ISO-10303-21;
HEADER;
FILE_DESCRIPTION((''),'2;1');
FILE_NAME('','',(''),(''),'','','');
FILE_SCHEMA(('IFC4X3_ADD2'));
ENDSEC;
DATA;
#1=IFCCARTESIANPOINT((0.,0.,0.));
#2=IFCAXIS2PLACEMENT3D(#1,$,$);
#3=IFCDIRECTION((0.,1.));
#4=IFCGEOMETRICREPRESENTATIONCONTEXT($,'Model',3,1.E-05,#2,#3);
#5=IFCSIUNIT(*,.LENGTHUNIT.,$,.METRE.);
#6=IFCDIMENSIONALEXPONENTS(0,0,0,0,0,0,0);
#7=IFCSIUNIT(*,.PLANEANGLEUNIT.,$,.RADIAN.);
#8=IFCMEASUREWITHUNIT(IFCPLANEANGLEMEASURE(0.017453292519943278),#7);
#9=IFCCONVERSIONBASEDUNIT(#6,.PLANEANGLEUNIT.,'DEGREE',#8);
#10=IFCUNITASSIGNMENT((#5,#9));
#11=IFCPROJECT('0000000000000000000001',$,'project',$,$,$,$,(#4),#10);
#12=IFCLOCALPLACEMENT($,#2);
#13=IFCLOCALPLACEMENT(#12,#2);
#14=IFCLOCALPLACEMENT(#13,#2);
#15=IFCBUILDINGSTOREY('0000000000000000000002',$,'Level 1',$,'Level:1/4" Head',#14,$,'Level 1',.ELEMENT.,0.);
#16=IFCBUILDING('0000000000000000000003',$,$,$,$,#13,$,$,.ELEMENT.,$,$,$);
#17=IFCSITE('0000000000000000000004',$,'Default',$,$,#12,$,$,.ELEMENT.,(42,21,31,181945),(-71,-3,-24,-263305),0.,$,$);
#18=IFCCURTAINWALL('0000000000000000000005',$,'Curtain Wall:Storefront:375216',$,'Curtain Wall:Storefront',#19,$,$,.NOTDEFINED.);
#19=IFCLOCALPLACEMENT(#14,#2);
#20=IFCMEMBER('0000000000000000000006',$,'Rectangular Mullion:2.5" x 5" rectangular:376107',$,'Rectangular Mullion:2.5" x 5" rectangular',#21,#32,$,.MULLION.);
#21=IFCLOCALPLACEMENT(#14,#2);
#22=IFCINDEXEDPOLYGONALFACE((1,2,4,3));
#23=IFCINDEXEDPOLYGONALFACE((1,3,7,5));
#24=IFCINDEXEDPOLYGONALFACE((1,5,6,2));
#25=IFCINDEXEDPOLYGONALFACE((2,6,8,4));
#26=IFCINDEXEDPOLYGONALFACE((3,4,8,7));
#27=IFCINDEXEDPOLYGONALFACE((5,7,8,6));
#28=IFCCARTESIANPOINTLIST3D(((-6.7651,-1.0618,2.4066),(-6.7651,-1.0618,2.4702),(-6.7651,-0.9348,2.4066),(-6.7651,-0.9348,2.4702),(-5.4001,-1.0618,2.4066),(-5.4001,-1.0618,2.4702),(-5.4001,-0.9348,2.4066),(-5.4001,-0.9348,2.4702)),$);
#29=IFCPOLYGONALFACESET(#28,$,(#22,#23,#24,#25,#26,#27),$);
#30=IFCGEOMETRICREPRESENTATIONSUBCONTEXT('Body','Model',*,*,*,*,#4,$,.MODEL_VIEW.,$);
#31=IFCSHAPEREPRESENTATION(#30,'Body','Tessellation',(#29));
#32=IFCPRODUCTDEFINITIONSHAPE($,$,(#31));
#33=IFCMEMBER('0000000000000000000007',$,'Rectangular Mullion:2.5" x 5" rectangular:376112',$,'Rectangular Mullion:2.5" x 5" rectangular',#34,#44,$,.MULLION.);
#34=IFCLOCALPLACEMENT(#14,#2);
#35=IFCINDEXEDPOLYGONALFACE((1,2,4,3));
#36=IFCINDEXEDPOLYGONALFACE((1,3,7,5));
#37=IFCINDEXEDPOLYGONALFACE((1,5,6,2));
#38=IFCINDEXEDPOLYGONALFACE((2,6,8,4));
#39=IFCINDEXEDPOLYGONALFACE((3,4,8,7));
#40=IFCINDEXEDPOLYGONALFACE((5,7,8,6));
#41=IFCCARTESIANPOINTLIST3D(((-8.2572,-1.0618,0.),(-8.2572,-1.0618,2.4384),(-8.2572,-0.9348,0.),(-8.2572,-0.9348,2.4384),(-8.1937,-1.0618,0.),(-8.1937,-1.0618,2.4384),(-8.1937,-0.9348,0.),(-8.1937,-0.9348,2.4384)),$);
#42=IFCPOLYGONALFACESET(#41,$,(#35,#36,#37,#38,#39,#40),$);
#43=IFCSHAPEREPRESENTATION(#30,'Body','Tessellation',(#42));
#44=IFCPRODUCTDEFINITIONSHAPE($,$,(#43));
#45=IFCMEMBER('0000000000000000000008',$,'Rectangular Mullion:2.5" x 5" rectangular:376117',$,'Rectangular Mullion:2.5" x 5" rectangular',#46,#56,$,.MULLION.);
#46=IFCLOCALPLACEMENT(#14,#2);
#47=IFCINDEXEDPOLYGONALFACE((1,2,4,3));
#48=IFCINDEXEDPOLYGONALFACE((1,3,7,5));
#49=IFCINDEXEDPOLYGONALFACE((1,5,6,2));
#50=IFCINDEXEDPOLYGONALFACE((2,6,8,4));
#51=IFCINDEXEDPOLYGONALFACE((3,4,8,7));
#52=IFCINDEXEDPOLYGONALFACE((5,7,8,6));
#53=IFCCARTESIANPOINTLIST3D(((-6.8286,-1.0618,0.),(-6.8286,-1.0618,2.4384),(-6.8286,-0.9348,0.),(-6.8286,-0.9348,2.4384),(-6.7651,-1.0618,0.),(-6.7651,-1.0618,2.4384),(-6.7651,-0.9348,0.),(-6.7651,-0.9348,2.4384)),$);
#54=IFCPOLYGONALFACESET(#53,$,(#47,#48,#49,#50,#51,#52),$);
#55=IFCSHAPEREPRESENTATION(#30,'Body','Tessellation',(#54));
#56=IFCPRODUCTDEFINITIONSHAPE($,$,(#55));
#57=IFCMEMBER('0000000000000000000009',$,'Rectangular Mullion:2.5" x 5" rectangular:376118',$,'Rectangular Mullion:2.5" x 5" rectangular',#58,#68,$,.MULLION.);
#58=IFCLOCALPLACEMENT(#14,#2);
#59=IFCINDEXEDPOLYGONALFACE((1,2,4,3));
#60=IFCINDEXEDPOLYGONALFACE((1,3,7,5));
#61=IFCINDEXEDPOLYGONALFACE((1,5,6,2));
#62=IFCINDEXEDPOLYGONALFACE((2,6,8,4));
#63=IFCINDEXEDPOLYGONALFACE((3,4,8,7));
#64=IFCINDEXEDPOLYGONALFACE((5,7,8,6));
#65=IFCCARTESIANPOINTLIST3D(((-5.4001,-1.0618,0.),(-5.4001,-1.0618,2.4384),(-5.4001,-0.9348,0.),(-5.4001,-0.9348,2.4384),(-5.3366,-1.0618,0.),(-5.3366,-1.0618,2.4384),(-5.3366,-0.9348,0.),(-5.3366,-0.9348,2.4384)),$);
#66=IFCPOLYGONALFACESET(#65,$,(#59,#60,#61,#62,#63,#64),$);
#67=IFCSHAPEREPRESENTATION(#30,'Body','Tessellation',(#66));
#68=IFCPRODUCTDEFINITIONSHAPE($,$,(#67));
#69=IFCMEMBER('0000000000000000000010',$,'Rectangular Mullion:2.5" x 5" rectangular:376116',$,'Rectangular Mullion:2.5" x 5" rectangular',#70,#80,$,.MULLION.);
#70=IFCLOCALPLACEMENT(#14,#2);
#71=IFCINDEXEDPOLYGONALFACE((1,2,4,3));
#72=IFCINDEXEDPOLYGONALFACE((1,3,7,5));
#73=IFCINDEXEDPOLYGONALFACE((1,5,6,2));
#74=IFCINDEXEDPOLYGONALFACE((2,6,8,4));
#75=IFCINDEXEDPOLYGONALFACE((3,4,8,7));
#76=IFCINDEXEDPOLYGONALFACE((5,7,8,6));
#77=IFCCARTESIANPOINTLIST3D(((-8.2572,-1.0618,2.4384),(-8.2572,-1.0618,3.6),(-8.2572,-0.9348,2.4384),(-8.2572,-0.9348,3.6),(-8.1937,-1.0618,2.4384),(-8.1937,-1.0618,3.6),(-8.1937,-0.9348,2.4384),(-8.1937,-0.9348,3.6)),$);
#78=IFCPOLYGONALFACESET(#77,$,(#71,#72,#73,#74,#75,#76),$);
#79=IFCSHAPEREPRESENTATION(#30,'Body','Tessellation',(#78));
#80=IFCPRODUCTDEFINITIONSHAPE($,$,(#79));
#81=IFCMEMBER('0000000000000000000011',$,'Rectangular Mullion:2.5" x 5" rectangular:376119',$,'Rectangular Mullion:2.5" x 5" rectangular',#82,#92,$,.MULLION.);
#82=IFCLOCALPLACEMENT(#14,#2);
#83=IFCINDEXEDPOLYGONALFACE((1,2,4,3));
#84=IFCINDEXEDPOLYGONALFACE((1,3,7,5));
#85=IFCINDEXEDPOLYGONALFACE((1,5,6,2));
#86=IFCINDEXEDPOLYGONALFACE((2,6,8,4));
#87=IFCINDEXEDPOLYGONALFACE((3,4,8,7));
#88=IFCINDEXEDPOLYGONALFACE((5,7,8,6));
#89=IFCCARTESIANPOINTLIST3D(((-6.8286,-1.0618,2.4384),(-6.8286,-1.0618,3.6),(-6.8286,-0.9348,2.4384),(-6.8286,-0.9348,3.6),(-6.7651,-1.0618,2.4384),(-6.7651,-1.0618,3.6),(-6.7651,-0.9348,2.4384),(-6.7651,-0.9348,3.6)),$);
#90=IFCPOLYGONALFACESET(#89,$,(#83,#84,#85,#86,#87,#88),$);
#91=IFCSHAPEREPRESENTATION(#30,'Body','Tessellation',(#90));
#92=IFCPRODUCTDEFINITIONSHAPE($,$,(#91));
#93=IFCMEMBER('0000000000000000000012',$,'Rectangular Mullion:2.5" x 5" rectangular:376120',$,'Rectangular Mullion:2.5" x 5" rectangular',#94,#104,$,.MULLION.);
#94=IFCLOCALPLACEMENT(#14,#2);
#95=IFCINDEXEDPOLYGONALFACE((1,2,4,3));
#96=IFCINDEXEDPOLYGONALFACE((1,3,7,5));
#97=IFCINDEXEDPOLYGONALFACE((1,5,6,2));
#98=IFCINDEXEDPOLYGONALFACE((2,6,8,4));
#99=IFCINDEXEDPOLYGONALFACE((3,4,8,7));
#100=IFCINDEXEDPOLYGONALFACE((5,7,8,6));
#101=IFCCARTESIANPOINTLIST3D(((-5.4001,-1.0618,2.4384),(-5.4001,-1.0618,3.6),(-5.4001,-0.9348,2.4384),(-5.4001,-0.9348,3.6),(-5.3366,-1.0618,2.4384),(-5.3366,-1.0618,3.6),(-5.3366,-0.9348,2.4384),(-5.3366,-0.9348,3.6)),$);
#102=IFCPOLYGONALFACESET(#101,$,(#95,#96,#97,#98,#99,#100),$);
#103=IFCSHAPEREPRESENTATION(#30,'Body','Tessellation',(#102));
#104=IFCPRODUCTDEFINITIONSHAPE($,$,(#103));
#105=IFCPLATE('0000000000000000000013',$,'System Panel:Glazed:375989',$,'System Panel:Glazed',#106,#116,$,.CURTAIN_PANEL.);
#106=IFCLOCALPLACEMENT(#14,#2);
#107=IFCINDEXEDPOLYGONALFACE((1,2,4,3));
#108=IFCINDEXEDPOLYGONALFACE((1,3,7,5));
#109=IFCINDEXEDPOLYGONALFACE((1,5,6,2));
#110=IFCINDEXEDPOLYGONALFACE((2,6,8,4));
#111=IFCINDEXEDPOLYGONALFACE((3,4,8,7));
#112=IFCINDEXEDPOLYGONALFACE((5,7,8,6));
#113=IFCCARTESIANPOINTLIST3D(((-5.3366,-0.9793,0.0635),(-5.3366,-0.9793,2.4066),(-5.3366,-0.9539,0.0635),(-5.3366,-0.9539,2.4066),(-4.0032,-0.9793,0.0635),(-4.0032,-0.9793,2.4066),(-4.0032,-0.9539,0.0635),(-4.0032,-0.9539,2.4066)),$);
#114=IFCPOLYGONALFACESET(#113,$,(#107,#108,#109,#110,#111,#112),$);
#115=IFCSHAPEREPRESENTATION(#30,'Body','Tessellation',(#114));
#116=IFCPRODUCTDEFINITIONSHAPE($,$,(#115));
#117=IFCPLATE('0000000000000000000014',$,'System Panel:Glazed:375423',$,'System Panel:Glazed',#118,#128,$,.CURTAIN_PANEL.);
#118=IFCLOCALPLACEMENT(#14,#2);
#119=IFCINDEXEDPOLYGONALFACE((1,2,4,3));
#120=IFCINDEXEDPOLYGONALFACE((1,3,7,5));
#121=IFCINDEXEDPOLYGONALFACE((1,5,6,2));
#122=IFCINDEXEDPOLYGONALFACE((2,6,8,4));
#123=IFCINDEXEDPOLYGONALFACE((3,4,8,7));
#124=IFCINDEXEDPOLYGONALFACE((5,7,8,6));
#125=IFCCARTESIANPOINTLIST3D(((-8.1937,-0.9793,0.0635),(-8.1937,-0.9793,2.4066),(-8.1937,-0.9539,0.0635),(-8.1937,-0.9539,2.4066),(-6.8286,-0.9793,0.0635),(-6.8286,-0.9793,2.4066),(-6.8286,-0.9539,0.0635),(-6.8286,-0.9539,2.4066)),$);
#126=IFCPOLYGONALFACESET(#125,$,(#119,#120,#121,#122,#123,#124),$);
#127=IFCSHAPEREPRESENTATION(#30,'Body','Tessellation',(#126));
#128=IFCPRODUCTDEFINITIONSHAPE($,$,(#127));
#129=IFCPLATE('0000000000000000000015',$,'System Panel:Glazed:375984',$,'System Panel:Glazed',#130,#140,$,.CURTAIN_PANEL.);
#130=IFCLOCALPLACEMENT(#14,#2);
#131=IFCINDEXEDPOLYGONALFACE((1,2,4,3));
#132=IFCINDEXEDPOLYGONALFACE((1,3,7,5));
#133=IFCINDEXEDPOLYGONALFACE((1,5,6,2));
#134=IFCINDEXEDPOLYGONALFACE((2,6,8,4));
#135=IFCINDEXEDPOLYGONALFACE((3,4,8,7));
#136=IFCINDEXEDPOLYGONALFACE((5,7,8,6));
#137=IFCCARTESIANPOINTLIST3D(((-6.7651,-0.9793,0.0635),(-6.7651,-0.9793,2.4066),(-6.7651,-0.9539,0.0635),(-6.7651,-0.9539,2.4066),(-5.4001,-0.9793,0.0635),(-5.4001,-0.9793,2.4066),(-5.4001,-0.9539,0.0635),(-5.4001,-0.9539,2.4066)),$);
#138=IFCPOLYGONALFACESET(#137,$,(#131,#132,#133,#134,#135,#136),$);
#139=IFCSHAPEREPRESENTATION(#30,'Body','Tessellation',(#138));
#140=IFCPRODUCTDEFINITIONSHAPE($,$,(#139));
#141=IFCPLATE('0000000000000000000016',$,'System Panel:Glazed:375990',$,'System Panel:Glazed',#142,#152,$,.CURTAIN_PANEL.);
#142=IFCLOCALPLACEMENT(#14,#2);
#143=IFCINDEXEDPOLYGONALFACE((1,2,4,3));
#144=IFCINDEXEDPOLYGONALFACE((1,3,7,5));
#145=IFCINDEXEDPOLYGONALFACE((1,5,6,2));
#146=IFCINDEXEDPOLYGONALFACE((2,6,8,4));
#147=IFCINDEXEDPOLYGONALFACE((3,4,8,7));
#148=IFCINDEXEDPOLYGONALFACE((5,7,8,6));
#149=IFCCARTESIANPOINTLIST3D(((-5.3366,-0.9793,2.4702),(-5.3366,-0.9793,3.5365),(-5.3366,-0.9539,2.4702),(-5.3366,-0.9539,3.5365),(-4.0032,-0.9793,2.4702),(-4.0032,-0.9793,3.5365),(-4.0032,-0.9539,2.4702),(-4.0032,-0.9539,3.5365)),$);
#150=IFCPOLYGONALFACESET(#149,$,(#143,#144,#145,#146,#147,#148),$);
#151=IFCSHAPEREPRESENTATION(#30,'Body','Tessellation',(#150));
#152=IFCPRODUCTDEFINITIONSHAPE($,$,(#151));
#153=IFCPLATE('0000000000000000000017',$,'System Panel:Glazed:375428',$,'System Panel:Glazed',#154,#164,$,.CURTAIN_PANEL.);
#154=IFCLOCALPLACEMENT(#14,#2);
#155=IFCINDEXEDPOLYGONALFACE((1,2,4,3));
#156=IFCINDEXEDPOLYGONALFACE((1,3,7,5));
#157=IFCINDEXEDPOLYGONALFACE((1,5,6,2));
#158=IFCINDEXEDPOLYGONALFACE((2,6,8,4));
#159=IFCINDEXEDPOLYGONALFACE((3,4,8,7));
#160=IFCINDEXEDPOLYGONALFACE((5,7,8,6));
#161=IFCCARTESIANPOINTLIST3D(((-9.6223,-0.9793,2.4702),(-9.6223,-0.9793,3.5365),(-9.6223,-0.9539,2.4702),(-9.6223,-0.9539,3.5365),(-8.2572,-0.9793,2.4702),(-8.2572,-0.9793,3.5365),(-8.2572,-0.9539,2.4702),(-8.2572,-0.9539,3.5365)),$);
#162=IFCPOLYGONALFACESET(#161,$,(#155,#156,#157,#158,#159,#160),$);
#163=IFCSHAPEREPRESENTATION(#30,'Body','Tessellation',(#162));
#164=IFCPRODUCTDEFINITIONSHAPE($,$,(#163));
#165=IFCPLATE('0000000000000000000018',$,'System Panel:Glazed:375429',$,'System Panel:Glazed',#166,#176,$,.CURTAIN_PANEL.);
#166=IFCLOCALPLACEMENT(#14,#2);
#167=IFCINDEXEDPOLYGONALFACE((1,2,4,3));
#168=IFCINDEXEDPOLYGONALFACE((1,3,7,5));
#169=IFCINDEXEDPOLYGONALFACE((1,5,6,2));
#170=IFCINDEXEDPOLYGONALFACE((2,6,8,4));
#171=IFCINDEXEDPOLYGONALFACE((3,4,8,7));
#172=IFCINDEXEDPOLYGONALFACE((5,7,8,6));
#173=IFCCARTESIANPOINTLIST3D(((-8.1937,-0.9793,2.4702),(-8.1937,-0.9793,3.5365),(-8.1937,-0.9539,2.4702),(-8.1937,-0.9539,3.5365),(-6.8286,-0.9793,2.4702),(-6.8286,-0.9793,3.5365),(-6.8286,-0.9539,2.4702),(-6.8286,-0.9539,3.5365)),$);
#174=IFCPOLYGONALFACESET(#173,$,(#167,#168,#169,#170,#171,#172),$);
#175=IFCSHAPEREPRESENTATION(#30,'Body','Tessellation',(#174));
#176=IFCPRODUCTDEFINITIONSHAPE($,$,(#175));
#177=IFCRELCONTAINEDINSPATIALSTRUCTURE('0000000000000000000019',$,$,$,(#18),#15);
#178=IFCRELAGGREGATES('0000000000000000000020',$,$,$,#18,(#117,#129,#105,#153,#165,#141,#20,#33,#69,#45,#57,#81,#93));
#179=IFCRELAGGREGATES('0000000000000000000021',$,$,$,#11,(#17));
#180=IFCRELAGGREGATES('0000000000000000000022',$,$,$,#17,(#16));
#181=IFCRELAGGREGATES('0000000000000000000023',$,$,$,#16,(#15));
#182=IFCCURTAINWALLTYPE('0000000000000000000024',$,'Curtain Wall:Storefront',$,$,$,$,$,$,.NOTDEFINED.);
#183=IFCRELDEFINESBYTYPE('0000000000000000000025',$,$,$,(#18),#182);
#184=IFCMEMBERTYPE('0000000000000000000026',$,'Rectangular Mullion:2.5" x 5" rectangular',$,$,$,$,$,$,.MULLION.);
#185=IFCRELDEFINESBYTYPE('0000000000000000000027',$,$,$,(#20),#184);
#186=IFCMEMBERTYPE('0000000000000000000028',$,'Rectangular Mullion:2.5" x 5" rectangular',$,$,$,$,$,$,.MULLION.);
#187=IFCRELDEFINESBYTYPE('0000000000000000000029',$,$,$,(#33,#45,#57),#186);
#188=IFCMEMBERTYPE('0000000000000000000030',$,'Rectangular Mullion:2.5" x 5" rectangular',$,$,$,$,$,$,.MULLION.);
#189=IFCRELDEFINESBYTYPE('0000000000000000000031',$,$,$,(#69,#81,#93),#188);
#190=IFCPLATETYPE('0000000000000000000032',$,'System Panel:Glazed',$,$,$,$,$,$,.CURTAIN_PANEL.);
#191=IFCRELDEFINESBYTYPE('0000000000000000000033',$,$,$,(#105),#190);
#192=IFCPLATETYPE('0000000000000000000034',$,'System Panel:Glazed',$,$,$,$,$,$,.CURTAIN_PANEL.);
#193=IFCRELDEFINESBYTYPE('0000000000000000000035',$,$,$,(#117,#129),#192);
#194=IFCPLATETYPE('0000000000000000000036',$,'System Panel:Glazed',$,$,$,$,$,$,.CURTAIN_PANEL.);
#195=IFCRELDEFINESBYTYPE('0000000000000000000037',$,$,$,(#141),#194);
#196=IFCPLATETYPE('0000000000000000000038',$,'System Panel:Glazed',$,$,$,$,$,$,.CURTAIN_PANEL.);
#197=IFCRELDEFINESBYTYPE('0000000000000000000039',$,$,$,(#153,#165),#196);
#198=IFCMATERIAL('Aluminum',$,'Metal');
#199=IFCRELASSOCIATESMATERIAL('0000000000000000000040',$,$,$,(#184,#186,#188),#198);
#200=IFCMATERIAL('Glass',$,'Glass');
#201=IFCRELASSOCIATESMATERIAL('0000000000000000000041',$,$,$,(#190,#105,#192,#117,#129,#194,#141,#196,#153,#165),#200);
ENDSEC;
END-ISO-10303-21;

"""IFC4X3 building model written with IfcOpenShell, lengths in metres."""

from ifc_helpers import new_model, entity, si_unit, converted_unit, direction, frame, frame_2d, origin, origin_2d_with_axis, place, context, subcontext, project, spatial, rectangle, extrude, source, transform, mapped, material, material_profile, profile_set, type_object, type_shapes, element, aggregate, save


model = new_model("IFC4X3")

# Units and contexts
model_context = context("Model", 3, precision=1e-05, world=origin(), true_north=direction((0.0, 1.0)))
body_context = subcontext(model_context, "Body", "Model", "MODEL_VIEW")
ifc_project = project(units=[si_unit("LENGTHUNIT", "METRE"), converted_unit("PLANEANGLEUNIT", "DEGREE", entity("IfcPlaneAngleMeasure", 0.017453292519943278), si_unit("PLANEANGLEUNIT", "RADIAN"), dimensions=[0, 0, 0, 0, 0, 0, 0])], contexts=[model_context])

# Site, building, storey
site_placement = place(None, origin())
site = spatial("IfcSite", under=ifc_project, at=site_placement, Name="Default", CompositionType="ELEMENT", RefLatitude=(42, 21, 31, 181945), RefLongitude=(-71, -3, -24, -263305), RefElevation=0.0)
building_placement = place(site_placement, origin())
building = spatial("IfcBuilding", under=site, at=building_placement, CompositionType="ELEMENT")
storey_placement = place(building_placement, origin())
storey = spatial("IfcBuildingStorey", under=building, at=storey_placement, Name="Level 1", ObjectType="Level:1/4\" Head", LongName="Level 1", CompositionType="ELEMENT", Elevation=0.0)

# Curtain wall, members, plates
curtain_wall_type = type_object("IfcCurtainWallType", Name="Curtain Wall:Storefront", PredefinedType="NOTDEFINED")
curtain_wall_placement = place(storey_placement, origin())
curtain_wall = element("IfcCurtainWall", 1, at=curtain_wall_placement, inside=storey, type_object=curtain_wall_type, Name="Curtain Wall:Storefront:375216", ObjectType="Curtain Wall:Storefront", PredefinedType="NOTDEFINED")
ifc_material_1 = material(Name="Aluminum", Category="Metal")
ifc_material_profile = material_profile(ifc_material_1, rectangle(XDim=0.0635, YDim=0.127, at=frame_2d((0.0, 0.0), x_axis=(1.0, 0.0))), Name="2.5\" x 5\" rectangular")
ifc_profile_set = profile_set([ifc_material_profile], Name="2.5\" x 5\" rectangular")
member_type_1 = type_object("IfcMemberType", Name="Rectangular Mullion:2.5\" x 5\" rectangular", PredefinedType="MULLION", material=ifc_profile_set)
shared_shape_1 = source(origin(), body_context, "Body", "SweptSolid", [
    extrude(rectangle(XDim=0.0635, YDim=0.127, at=origin_2d_with_axis()), frame((0.0, 0.0, -1.3651), z_axis=(0.0, 0.0, 1.0), x_axis=(-1.0, 0.0, 0.0)), (0.0, 0.0, 1.0), 1.3651),
])
type_shapes(member_type_1, [shared_shape_1])
member_1_placement = place(curtain_wall_placement, frame((-5.4001, -0.9983, 2.4384), z_axis=(1.0, 0.0, 0.0), x_axis=(0.0, 0.0, 1.0)))
member_1 = element("IfcMember", 2, at=member_1_placement, type_object=member_type_1, Name="Rectangular Mullion:2.5\" x 5\" rectangular:376107", ObjectType="Rectangular Mullion:2.5\" x 5\" rectangular", PredefinedType="MULLION", context=body_context, shape_type="MappedRepresentation", body=[
    mapped(shared_shape_1, transform((0.0, 0.0, 0.0), scale=1.0)),
])
member_type_2 = type_object("IfcMemberType", Name="Rectangular Mullion:2.5\" x 5\" rectangular", PredefinedType="MULLION", material=ifc_profile_set)
shared_shape_2 = source(origin(), body_context, "Body", "SweptSolid", [
    extrude(rectangle(XDim=0.0635, YDim=0.127, at=origin_2d_with_axis()), frame((0.0, 0.0, -2.4384), z_axis=(0.0, 0.0, 1.0), x_axis=(-1.0, 0.0, 0.0)), (0.0, 0.0, 1.0), 2.4384),
])
type_shapes(member_type_2, [shared_shape_2])
member_2_placement = place(curtain_wall_placement, frame((-8.2254, -0.9983, 0.0), z_axis=(0.0, 0.0, -1.0), x_axis=(1.0, 0.0, 0.0)))
member_2 = element("IfcMember", 3, at=member_2_placement, type_object=member_type_2, Name="Rectangular Mullion:2.5\" x 5\" rectangular:376112", ObjectType="Rectangular Mullion:2.5\" x 5\" rectangular", PredefinedType="MULLION", context=body_context, shape_type="MappedRepresentation", body=[
    mapped(shared_shape_2, transform((0.0, 0.0, 0.0), scale=1.0)),
])
member_3_placement = place(curtain_wall_placement, frame((-6.7969, -0.9983, 0.0), z_axis=(0.0, 0.0, -1.0), x_axis=(1.0, 0.0, 0.0)))
member_3 = element("IfcMember", 4, at=member_3_placement, type_object=member_type_2, Name="Rectangular Mullion:2.5\" x 5\" rectangular:376117", ObjectType="Rectangular Mullion:2.5\" x 5\" rectangular", PredefinedType="MULLION", context=body_context, shape_type="MappedRepresentation", body=[
    mapped(shared_shape_2, transform((0.0, 0.0, 0.0), scale=1.0)),
])
member_4_placement = place(curtain_wall_placement, frame((-5.3683, -0.9983, 0.0), z_axis=(0.0, 0.0, -1.0), x_axis=(1.0, 0.0, 0.0)))
member_4 = element("IfcMember", 5, at=member_4_placement, type_object=member_type_2, Name="Rectangular Mullion:2.5\" x 5\" rectangular:376118", ObjectType="Rectangular Mullion:2.5\" x 5\" rectangular", PredefinedType="MULLION", context=body_context, shape_type="MappedRepresentation", body=[
    mapped(shared_shape_2, transform((0.0, 0.0, 0.0), scale=1.0)),
])
member_type_3 = type_object("IfcMemberType", Name="Rectangular Mullion:2.5\" x 5\" rectangular", PredefinedType="MULLION", material=ifc_profile_set)
shared_shape_3 = source(origin(), body_context, "Body", "SweptSolid", [
    extrude(rectangle(XDim=0.0635, YDim=0.127, at=origin_2d_with_axis()), frame((0.0, 0.0, -1.1616), z_axis=(0.0, 0.0, 1.0), x_axis=(-1.0, 0.0, 0.0)), (0.0, 0.0, 1.0), 1.1616),
])
type_shapes(member_type_3, [shared_shape_3])
member_5_placement = place(curtain_wall_placement, frame((-8.2254, -0.9983, 2.4384), z_axis=(0.0, 0.0, -1.0), x_axis=(1.0, 0.0, 0.0)))
member_5 = element("IfcMember", 6, at=member_5_placement, type_object=member_type_3, Name="Rectangular Mullion:2.5\" x 5\" rectangular:376116", ObjectType="Rectangular Mullion:2.5\" x 5\" rectangular", PredefinedType="MULLION", context=body_context, shape_type="MappedRepresentation", body=[
    mapped(shared_shape_3, transform((0.0, 0.0, 0.0), scale=1.0)),
])
member_6_placement = place(curtain_wall_placement, frame((-6.7969, -0.9983, 2.4384), z_axis=(0.0, 0.0, -1.0), x_axis=(1.0, 0.0, 0.0)))
member_6 = element("IfcMember", 7, at=member_6_placement, type_object=member_type_3, Name="Rectangular Mullion:2.5\" x 5\" rectangular:376119", ObjectType="Rectangular Mullion:2.5\" x 5\" rectangular", PredefinedType="MULLION", context=body_context, shape_type="MappedRepresentation", body=[
    mapped(shared_shape_3, transform((0.0, 0.0, 0.0), scale=1.0)),
])
member_7_placement = place(curtain_wall_placement, frame((-5.3683, -0.9983, 2.4384), z_axis=(0.0, 0.0, -1.0), x_axis=(1.0, 0.0, 0.0)))
member_7 = element("IfcMember", 8, at=member_7_placement, type_object=member_type_3, Name="Rectangular Mullion:2.5\" x 5\" rectangular:376120", ObjectType="Rectangular Mullion:2.5\" x 5\" rectangular", PredefinedType="MULLION", context=body_context, shape_type="MappedRepresentation", body=[
    mapped(shared_shape_3, transform((0.0, 0.0, 0.0), scale=1.0)),
])
ifc_material_2 = material(Name="Glass", Category="Glass")
plate_type_1 = type_object("IfcPlateType", Name="System Panel:Glazed", PredefinedType="CURTAIN_PANEL", material=ifc_material_2)
shared_shape_4 = source(origin(), body_context, "Body", "SweptSolid", [
    extrude(rectangle(XDim=0.0254, YDim=1.3333, at=frame_2d((0.0, 0.0), x_axis=(1.0, 0.0))), frame((0.6667, 0.0127, 0.0), z_axis=(0.0, 0.0, 1.0), x_axis=(0.0, 1.0, 0.0)), (0.0, 0.0, 1.0), 2.3432),
])
type_shapes(plate_type_1, [shared_shape_4])
plate_1_placement = place(curtain_wall_placement, frame((-5.3366, -0.9793, 0.0635)))
plate_1 = element("IfcPlate", 9, at=plate_1_placement, type_object=plate_type_1, material=ifc_material_2, Name="System Panel:Glazed:375989", ObjectType="System Panel:Glazed", PredefinedType="CURTAIN_PANEL", context=body_context, shape_type="MappedRepresentation", body=[
    mapped(shared_shape_4, transform((0.0, 0.0, 0.0), scale=1.0)),
])
plate_type_2 = type_object("IfcPlateType", Name="System Panel:Glazed", PredefinedType="CURTAIN_PANEL", material=ifc_material_2)
shared_shape_5 = source(origin(), body_context, "Body", "SweptSolid", [
    extrude(rectangle(XDim=0.0254, YDim=1.3651, at=frame_2d((0.0, 0.0), x_axis=(1.0, 0.0))), frame((0.6825, 0.0127, 0.0), z_axis=(0.0, 0.0, 1.0), x_axis=(0.0, 1.0, 0.0)), (0.0, 0.0, 1.0), 2.3432),
])
type_shapes(plate_type_2, [shared_shape_5])
plate_2_placement = place(curtain_wall_placement, frame((-8.1937, -0.9793, 0.0635)))
plate_2 = element("IfcPlate", 10, at=plate_2_placement, type_object=plate_type_2, material=ifc_material_2, Name="System Panel:Glazed:375423", ObjectType="System Panel:Glazed", PredefinedType="CURTAIN_PANEL", context=body_context, shape_type="MappedRepresentation", body=[
    mapped(shared_shape_5, transform((0.0, 0.0, 0.0), scale=1.0)),
])
plate_3_placement = place(curtain_wall_placement, frame((-6.7651, -0.9793, 0.0635)))
plate_3 = element("IfcPlate", 11, at=plate_3_placement, type_object=plate_type_2, material=ifc_material_2, Name="System Panel:Glazed:375984", ObjectType="System Panel:Glazed", PredefinedType="CURTAIN_PANEL", context=body_context, shape_type="MappedRepresentation", body=[
    mapped(shared_shape_5, transform((0.0, 0.0, 0.0), scale=1.0)),
])
plate_type_3 = type_object("IfcPlateType", Name="System Panel:Glazed", PredefinedType="CURTAIN_PANEL", material=ifc_material_2)
shared_shape_6 = source(origin(), body_context, "Body", "SweptSolid", [
    extrude(rectangle(XDim=0.0254, YDim=1.3333, at=frame_2d((0.0, 0.0), x_axis=(1.0, 0.0))), frame((0.6667, 0.0127, 0.0), z_axis=(0.0, 0.0, 1.0), x_axis=(0.0, 1.0, 0.0)), (0.0, 0.0, 1.0), 1.0663),
])
type_shapes(plate_type_3, [shared_shape_6])
plate_4_placement = place(curtain_wall_placement, frame((-5.3366, -0.9793, 2.4701)))
plate_4 = element("IfcPlate", 12, at=plate_4_placement, type_object=plate_type_3, material=ifc_material_2, Name="System Panel:Glazed:375990", ObjectType="System Panel:Glazed", PredefinedType="CURTAIN_PANEL", context=body_context, shape_type="MappedRepresentation", body=[
    mapped(shared_shape_6, transform((0.0, 0.0, 0.0), scale=1.0)),
])
plate_type_4 = type_object("IfcPlateType", Name="System Panel:Glazed", PredefinedType="CURTAIN_PANEL", material=ifc_material_2)
shared_shape_7 = source(origin(), body_context, "Body", "SweptSolid", [
    extrude(rectangle(XDim=0.0254, YDim=1.3651, at=frame_2d((0.0, 0.0), x_axis=(1.0, 0.0))), frame((0.6825, 0.0127, 0.0), z_axis=(0.0, 0.0, 1.0), x_axis=(0.0, 1.0, 0.0)), (0.0, 0.0, 1.0), 1.0663),
])
type_shapes(plate_type_4, [shared_shape_7])
plate_5_placement = place(curtain_wall_placement, frame((-9.6223, -0.9793, 2.4701)))
plate_5 = element("IfcPlate", 13, at=plate_5_placement, type_object=plate_type_4, material=ifc_material_2, Name="System Panel:Glazed:375428", ObjectType="System Panel:Glazed", PredefinedType="CURTAIN_PANEL", context=body_context, shape_type="MappedRepresentation", body=[
    mapped(shared_shape_7, transform((0.0, 0.0, 0.0), scale=1.0)),
])
plate_6_placement = place(curtain_wall_placement, frame((-8.1937, -0.9793, 2.4701)))
plate_6 = element("IfcPlate", 14, at=plate_6_placement, type_object=plate_type_4, material=ifc_material_2, Name="System Panel:Glazed:375429", ObjectType="System Panel:Glazed", PredefinedType="CURTAIN_PANEL", context=body_context, shape_type="MappedRepresentation", body=[
    mapped(shared_shape_7, transform((0.0, 0.0, 0.0), scale=1.0)),
])
aggregate(curtain_wall, [plate_2, plate_3, plate_1, plate_5, plate_6, plate_4, member_1, member_2, member_5, member_3, member_4, member_6, member_7])

save(model, "model.ifc")
